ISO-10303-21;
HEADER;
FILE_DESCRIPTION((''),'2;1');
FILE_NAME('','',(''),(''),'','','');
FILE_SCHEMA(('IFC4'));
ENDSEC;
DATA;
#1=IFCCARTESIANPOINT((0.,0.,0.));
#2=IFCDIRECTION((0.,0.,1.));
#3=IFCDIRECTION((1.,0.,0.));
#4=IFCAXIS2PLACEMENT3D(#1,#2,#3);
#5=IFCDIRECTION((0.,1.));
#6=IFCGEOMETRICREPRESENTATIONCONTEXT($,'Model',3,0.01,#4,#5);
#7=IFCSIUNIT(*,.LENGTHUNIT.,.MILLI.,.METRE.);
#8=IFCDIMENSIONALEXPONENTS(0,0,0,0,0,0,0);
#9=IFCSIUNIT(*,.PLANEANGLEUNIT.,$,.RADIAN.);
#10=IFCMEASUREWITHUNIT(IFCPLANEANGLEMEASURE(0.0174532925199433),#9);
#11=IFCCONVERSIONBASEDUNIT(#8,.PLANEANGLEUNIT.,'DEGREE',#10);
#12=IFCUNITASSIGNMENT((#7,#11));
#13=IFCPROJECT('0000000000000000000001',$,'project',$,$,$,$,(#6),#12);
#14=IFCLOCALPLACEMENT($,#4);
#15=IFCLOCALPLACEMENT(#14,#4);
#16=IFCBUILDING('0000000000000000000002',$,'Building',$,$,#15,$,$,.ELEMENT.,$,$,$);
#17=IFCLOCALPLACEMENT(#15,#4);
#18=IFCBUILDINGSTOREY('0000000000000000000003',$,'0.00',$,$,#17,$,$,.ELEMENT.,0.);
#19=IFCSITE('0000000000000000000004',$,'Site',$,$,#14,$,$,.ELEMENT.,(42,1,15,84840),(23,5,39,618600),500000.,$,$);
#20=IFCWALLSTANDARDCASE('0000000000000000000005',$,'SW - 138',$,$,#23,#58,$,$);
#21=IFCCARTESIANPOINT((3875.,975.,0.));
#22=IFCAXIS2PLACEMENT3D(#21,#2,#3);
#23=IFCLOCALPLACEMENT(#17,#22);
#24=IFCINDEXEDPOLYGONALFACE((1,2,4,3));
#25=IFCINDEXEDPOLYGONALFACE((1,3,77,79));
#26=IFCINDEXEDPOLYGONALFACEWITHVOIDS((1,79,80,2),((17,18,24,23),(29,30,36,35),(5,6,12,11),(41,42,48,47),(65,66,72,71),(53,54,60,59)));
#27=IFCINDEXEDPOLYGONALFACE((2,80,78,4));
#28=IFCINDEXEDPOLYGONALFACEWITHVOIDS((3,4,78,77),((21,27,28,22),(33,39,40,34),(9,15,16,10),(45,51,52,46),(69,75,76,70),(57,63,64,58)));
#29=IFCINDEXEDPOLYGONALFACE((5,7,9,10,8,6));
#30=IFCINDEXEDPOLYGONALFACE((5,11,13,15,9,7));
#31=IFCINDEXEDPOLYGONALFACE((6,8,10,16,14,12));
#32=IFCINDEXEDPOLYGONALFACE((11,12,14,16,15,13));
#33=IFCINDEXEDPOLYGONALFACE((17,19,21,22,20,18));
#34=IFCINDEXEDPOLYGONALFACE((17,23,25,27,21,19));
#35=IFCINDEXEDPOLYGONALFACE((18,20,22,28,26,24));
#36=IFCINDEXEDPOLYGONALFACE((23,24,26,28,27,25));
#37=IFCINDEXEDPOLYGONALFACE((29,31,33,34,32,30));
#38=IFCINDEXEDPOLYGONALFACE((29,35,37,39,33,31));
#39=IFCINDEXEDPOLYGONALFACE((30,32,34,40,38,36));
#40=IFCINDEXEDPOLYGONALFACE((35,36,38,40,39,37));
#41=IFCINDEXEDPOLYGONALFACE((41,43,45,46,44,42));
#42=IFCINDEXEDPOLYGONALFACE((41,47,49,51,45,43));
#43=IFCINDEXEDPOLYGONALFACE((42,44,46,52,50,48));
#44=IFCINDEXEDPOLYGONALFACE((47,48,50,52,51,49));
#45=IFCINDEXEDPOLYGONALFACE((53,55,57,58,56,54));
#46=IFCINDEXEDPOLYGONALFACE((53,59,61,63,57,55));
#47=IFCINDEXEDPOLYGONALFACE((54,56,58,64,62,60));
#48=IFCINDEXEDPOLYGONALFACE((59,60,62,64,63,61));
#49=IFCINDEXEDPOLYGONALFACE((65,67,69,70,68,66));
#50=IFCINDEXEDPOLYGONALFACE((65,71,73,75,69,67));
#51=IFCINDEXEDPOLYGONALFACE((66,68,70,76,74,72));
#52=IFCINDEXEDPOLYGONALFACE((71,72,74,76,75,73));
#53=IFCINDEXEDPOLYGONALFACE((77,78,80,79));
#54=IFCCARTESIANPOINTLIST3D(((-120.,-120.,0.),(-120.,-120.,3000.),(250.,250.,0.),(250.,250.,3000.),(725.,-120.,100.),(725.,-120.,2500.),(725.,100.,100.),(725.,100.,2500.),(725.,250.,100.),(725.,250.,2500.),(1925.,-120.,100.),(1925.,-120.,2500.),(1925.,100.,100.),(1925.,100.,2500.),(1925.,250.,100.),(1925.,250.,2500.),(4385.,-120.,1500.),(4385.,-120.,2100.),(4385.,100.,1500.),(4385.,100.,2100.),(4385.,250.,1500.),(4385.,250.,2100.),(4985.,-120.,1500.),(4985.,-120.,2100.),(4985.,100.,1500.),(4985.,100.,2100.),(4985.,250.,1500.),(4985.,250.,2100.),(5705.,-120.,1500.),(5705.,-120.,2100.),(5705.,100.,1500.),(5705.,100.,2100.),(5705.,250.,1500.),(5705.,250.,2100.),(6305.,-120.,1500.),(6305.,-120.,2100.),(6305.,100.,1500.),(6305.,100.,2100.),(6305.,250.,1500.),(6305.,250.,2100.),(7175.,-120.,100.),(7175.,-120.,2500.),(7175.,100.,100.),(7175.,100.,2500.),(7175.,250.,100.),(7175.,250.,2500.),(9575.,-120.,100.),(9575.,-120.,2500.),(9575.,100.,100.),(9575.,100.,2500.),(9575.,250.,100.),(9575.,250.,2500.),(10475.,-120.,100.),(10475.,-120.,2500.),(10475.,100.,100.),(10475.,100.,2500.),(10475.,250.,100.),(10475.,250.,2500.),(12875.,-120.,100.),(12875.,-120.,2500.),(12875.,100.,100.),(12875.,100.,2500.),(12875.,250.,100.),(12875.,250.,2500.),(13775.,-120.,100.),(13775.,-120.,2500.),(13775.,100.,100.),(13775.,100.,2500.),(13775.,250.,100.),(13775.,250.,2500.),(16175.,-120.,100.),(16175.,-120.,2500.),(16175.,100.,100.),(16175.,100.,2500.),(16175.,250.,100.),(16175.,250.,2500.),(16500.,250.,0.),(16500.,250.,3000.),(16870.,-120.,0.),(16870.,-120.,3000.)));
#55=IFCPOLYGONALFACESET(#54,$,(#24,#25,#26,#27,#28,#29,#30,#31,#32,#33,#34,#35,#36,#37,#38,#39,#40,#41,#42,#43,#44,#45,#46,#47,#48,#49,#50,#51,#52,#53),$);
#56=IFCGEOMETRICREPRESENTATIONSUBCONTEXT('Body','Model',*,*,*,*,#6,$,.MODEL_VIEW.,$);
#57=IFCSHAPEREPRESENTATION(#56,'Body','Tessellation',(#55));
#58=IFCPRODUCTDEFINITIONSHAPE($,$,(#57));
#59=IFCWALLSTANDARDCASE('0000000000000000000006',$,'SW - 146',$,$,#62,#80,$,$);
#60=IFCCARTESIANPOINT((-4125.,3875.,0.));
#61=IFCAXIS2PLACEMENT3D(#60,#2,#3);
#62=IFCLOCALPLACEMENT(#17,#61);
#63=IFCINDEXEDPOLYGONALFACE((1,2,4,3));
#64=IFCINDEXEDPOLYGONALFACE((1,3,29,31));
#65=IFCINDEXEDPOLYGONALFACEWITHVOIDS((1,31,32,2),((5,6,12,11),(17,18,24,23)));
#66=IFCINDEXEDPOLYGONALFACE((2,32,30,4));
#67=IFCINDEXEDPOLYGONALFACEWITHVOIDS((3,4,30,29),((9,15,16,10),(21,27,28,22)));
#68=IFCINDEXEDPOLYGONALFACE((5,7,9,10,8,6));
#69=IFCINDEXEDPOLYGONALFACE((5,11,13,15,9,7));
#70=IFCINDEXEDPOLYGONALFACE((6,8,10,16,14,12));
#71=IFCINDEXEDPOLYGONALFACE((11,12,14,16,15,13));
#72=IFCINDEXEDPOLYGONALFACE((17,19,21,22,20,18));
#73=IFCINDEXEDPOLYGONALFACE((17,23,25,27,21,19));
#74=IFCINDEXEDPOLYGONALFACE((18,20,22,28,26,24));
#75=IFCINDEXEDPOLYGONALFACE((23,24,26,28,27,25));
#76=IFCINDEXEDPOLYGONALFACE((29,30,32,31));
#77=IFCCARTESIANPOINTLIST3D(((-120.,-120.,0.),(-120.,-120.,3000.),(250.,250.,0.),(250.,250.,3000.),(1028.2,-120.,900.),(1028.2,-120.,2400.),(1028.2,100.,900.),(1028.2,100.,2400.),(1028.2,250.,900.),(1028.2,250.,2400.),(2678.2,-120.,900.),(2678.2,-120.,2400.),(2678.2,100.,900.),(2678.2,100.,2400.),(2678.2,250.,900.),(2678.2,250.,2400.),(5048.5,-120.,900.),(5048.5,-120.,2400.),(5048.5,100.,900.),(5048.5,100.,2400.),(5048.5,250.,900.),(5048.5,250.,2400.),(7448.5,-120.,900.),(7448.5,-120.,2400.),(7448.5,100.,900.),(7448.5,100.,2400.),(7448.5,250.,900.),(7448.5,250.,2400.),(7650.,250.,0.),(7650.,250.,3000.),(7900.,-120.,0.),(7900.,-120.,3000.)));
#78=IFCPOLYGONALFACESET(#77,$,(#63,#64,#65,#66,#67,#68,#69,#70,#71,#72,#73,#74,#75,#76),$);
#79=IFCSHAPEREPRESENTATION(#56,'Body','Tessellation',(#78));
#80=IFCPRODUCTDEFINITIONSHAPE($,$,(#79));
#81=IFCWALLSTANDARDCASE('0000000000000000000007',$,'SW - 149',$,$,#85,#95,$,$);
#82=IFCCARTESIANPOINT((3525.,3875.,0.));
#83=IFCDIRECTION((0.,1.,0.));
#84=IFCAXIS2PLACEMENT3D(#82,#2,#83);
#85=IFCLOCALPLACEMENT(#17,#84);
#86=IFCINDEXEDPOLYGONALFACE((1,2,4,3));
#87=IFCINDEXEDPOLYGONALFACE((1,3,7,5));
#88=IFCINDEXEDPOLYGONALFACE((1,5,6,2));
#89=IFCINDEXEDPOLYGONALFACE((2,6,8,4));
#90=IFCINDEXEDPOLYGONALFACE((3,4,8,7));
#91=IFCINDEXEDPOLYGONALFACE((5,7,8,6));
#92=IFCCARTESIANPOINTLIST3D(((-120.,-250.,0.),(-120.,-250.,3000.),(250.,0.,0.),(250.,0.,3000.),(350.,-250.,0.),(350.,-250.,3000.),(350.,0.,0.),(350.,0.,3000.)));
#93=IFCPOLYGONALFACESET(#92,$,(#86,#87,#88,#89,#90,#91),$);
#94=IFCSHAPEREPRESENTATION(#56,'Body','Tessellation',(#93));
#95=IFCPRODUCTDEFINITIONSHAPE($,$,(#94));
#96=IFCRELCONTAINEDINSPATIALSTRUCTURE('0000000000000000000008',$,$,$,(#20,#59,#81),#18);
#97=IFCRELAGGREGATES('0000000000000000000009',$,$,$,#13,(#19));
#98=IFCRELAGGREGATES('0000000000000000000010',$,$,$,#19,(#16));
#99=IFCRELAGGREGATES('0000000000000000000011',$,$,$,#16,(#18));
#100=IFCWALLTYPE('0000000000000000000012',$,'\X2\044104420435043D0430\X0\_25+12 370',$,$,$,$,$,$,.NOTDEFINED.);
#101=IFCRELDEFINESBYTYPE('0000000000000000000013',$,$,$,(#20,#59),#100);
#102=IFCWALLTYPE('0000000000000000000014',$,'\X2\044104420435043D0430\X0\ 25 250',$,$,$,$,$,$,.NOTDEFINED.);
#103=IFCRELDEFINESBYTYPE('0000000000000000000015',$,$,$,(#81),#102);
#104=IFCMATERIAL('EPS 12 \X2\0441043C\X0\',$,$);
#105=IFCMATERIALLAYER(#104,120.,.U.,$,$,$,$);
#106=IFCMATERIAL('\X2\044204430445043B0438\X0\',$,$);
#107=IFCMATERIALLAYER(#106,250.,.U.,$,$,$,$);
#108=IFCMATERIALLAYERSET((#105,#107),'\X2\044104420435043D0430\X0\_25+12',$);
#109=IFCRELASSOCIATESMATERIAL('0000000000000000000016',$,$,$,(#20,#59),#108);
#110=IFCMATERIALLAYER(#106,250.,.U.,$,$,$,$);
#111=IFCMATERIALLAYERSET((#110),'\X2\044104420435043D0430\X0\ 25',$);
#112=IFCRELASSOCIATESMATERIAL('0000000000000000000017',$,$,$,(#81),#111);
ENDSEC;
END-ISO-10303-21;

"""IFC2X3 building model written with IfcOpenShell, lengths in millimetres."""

from ifc_helpers import new_model, entity, si_unit, converted_unit, direction, frame, origin_with_axes, origin_2d_with_axis, place, context, subcontext, project, spatial, polyline, rectangle, outline, extrude, material, layer, layer_set, layer_usage, type_object, element, save


model = new_model("IFC2X3")

# Units and contexts
model_context = context("Model", 3, precision=0.01, world=origin_with_axes(), true_north=direction((0.0, 1.0)))
body_context = subcontext(model_context, "Body", "Model", "MODEL_VIEW")
ifc_project = project(units=[si_unit("LENGTHUNIT", "METRE", prefix="MILLI"), converted_unit("PLANEANGLEUNIT", "DEGREE", entity("IfcPlaneAngleMeasure", 0.0174532925199433), si_unit("PLANEANGLEUNIT", "RADIAN"), dimensions=[0, 0, 0, 0, 0, 0, 0])], contexts=[model_context])

# Site, building, storey
site_placement = place(None, origin_with_axes())
site = spatial("IfcSite", under=ifc_project, at=site_placement, Name="Site", CompositionType="ELEMENT", RefLatitude=(42, 1, 15, 84840), RefLongitude=(23, 5, 39, 618600), RefElevation=500000.0)
building_placement = place(site_placement, origin_with_axes())
building = spatial("IfcBuilding", under=site, at=building_placement, Name="Building", CompositionType="ELEMENT")
storey_placement = place(building_placement, origin_with_axes())
storey = spatial("IfcBuildingStorey", under=building, at=storey_placement, Name="0.00", CompositionType="ELEMENT", Elevation=0.0)

# Walls, openings
ifc_material_1 = material(Name="EPS 12 см")
ifc_layer_1 = layer(ifc_material_1, 120.0, ventilated="UNKNOWN")
ifc_material_2 = material(Name="тухли")
ifc_layer_2 = layer(ifc_material_2, 250.0, ventilated="UNKNOWN")
ifc_layer_set_1 = layer_set([ifc_layer_1, ifc_layer_2], Name="стена_25+12")
ifc_layer_usage_1 = layer_usage(ifc_layer_set_1, "AXIS2", "POSITIVE", -120.0)
wall_type_1 = type_object("IfcWallType", Name="стена_25+12 370", PredefinedType="NOTDEFINED")
wall_1_placement = place(storey_placement, frame((3875.0, 975.0, 0.0), z_axis=(0.0, 0.0, 1.0), x_axis=(1.0, 0.0, 0.0)))
wall_1 = element("IfcWallStandardCase", 1, at=wall_1_placement, inside=storey, type_object=wall_type_1, material=ifc_layer_usage_1, Name="SW - 138", context=body_context, shape_type="SweptSolid", body=[
    extrude(outline(polyline([(-120.0, -120.0), (16870.0, -120.0), (16500.0, 250.0), (250.0, 250.0), (-120.0, -120.0)])), origin_with_axes(), (0.0, 0.0, 1.0), 3000.0),
])
opening_1_placement = place(wall_1_placement, frame((11675.0, 0.0, 100.0), z_axis=(0.0, 0.0, 1.0), x_axis=(1.0, 0.0, 0.0)))
element("IfcOpeningElement", 2, at=opening_1_placement, cuts=wall_1, context=body_context, shape_type="SweptSolid", body=[
    extrude(rectangle(XDim=2400.0, YDim=2400.0, at=origin_2d_with_axis()), frame((0.0, 100.0, 1200.0), z_axis=(0.0, 1.0, 0.0), x_axis=(1.0, 0.0, 0.0)), (0.0, 0.0, -1.0), 590.0),
    extrude(rectangle(XDim=2400.0, YDim=2400.0, at=origin_2d_with_axis()), frame((0.0, 100.0, 1200.0), z_axis=(0.0, -1.0, 0.0), x_axis=(1.0, 0.0, 0.0)), (0.0, 0.0, -1.0), 520.0),
])
opening_2_placement = place(wall_1_placement, frame((8375.0, 0.0, 100.0), z_axis=(0.0, 0.0, 1.0), x_axis=(1.0, 0.0, 0.0)))
element("IfcOpeningElement", 3, at=opening_2_placement, cuts=wall_1, context=body_context, shape_type="SweptSolid", body=[
    extrude(rectangle(XDim=2400.0, YDim=2400.0, at=origin_2d_with_axis()), frame((0.0, 100.0, 1200.0), z_axis=(0.0, 1.0, 0.0), x_axis=(1.0, 0.0, 0.0)), (0.0, 0.0, -1.0), 590.0),
    extrude(rectangle(XDim=2400.0, YDim=2400.0, at=origin_2d_with_axis()), frame((0.0, 100.0, 1200.0), z_axis=(0.0, -1.0, 0.0), x_axis=(1.0, 0.0, 0.0)), (0.0, 0.0, -1.0), 520.0),
])
opening_3_placement = place(wall_1_placement, frame((14975.0, 0.0, 100.0), z_axis=(0.0, 0.0, 1.0), x_axis=(1.0, 0.0, 0.0)))
element("IfcOpeningElement", 4, at=opening_3_placement, cuts=wall_1, context=body_context, shape_type="SweptSolid", body=[
    extrude(rectangle(XDim=2400.0, YDim=2400.0, at=origin_2d_with_axis()), frame((0.0, 100.0, 1200.0), z_axis=(0.0, 1.0, 0.0), x_axis=(1.0, 0.0, 0.0)), (0.0, 0.0, -1.0), 590.0),
    extrude(rectangle(XDim=2400.0, YDim=2400.0, at=origin_2d_with_axis()), frame((0.0, 100.0, 1200.0), z_axis=(0.0, -1.0, 0.0), x_axis=(1.0, 0.0, 0.0)), (0.0, 0.0, -1.0), 520.0),
])
opening_4_placement = place(wall_1_placement, frame((4685.0, 0.0, 1500.0), z_axis=(0.0, 0.0, 1.0), x_axis=(1.0, 0.0, 0.0)))
element("IfcOpeningElement", 5, at=opening_4_placement, cuts=wall_1, context=body_context, shape_type="SweptSolid", body=[
    extrude(rectangle(XDim=600.0, YDim=600.0, at=origin_2d_with_axis()), frame((0.0, 100.0, 300.0), z_axis=(0.0, 1.0, 0.0), x_axis=(1.0, 0.0, 0.0)), (0.0, 0.0, -1.0), 590.0),
    extrude(rectangle(XDim=600.0, YDim=600.0, at=origin_2d_with_axis()), frame((0.0, 100.0, 300.0), z_axis=(0.0, -1.0, 0.0), x_axis=(1.0, 0.0, 0.0)), (0.0, 0.0, -1.0), 520.0),
])
opening_5_placement = place(wall_1_placement, frame((1325.0, 0.0, 100.0), z_axis=(0.0, 0.0, 1.0), x_axis=(1.0, 0.0, 0.0)))
element("IfcOpeningElement", 6, at=opening_5_placement, cuts=wall_1, context=body_context, shape_type="SweptSolid", body=[
    extrude(rectangle(XDim=1200.0, YDim=2400.0, at=origin_2d_with_axis()), frame((0.0, 100.0, 1200.0), z_axis=(0.0, 1.0, 0.0), x_axis=(1.0, 0.0, 0.0)), (0.0, 0.0, -1.0), 590.0),
    extrude(rectangle(XDim=1200.0, YDim=2400.0, at=origin_2d_with_axis()), frame((0.0, 100.0, 1200.0), z_axis=(0.0, -1.0, 0.0), x_axis=(1.0, 0.0, 0.0)), (0.0, 0.0, -1.0), 520.0),
])
opening_6_placement = place(wall_1_placement, frame((6005.0, 0.0, 1500.0), z_axis=(0.0, 0.0, 1.0), x_axis=(1.0, 0.0, 0.0)))
element("IfcOpeningElement", 7, at=opening_6_placement, cuts=wall_1, context=body_context, shape_type="SweptSolid", body=[
    extrude(rectangle(XDim=600.0, YDim=600.0, at=origin_2d_with_axis()), frame((0.0, 100.0, 300.0), z_axis=(0.0, 1.0, 0.0), x_axis=(1.0, 0.0, 0.0)), (0.0, 0.0, -1.0), 590.0),
    extrude(rectangle(XDim=600.0, YDim=600.0, at=origin_2d_with_axis()), frame((0.0, 100.0, 300.0), z_axis=(0.0, -1.0, 0.0), x_axis=(1.0, 0.0, 0.0)), (0.0, 0.0, -1.0), 520.0),
])
ifc_layer_usage_2 = layer_usage(ifc_layer_set_1, "AXIS2", "POSITIVE", -120.0)
wall_2_placement = place(storey_placement, frame((-4125.0, 3875.0, 0.0), z_axis=(0.0, 0.0, 1.0), x_axis=(1.0, 0.0, 0.0)))
wall_2 = element("IfcWallStandardCase", 8, at=wall_2_placement, inside=storey, type_object=wall_type_1, material=ifc_layer_usage_2, Name="SW - 146", context=body_context, shape_type="SweptSolid", body=[
    extrude(outline(polyline([(-120.0, -120.0), (7900.0, -120.0), (7650.0, 250.0), (250.0, 250.0), (-120.0, -120.0)])), origin_with_axes(), (0.0, 0.0, 1.0), 3000.0),
])
opening_7_placement = place(wall_2_placement, frame((6248.5, 0.0, 900.0), z_axis=(0.0, 0.0, 1.0), x_axis=(1.0, 0.0, 0.0)))
element("IfcOpeningElement", 9, at=opening_7_placement, cuts=wall_2, context=body_context, shape_type="SweptSolid", body=[
    extrude(rectangle(XDim=2400.0, YDim=1500.0, at=origin_2d_with_axis()), frame((0.0, 100.0, 750.0), z_axis=(0.0, -1.0, 0.0), x_axis=(-1.0, 0.0, 0.0)), (0.0, 0.0, 1.0), 590.0),
    extrude(rectangle(XDim=2400.0, YDim=1500.0, at=origin_2d_with_axis()), frame((0.0, 100.0, 750.0), z_axis=(0.0, 1.0, 0.0), x_axis=(-1.0, 0.0, 0.0)), (0.0, 0.0, 1.0), 520.0),
])
opening_8_placement = place(wall_2_placement, frame((1853.2, 0.0, 900.0), z_axis=(0.0, 0.0, 1.0), x_axis=(1.0, 0.0, 0.0)))
element("IfcOpeningElement", 10, at=opening_8_placement, cuts=wall_2, context=body_context, shape_type="SweptSolid", body=[
    extrude(rectangle(XDim=1650.0, YDim=1500.0, at=origin_2d_with_axis()), frame((0.0, 100.0, 750.0), z_axis=(0.0, -1.0, 0.0), x_axis=(-1.0, 0.0, 0.0)), (0.0, 0.0, 1.0), 590.0),
    extrude(rectangle(XDim=1650.0, YDim=1500.0, at=origin_2d_with_axis()), frame((0.0, 100.0, 750.0), z_axis=(0.0, 1.0, 0.0), x_axis=(-1.0, 0.0, 0.0)), (0.0, 0.0, 1.0), 520.0),
])

# Shared definitions
ifc_layer_3 = layer(ifc_material_2, 250.0, ventilated="UNKNOWN")
ifc_layer_set_2 = layer_set([ifc_layer_3], Name="стена 25")
wall_type_2 = type_object("IfcWallType", Name="стена 25 250", PredefinedType="NOTDEFINED")

# Wall
ifc_layer_usage_3 = layer_usage(ifc_layer_set_2, "AXIS2", "NEGATIVE", 0.0)
wall_3_placement = place(storey_placement, frame((3525.0, 3875.0, 0.0), z_axis=(0.0, 0.0, 1.0), x_axis=(0.0, 1.0, 0.0)))
element("IfcWallStandardCase", 11, at=wall_3_placement, inside=storey, type_object=wall_type_2, material=ifc_layer_usage_3, Name="SW - 149", context=body_context, shape_type="SweptSolid", body=[
    extrude(outline(polyline([(-120.0, -250.0), (350.0, -250.0), (350.0, 0.0), (250.0, 0.0), (-120.0, -250.0)])), origin_with_axes(), (0.0, 0.0, 1.0), 3000.0),
])

save(model, "model.ifc")
